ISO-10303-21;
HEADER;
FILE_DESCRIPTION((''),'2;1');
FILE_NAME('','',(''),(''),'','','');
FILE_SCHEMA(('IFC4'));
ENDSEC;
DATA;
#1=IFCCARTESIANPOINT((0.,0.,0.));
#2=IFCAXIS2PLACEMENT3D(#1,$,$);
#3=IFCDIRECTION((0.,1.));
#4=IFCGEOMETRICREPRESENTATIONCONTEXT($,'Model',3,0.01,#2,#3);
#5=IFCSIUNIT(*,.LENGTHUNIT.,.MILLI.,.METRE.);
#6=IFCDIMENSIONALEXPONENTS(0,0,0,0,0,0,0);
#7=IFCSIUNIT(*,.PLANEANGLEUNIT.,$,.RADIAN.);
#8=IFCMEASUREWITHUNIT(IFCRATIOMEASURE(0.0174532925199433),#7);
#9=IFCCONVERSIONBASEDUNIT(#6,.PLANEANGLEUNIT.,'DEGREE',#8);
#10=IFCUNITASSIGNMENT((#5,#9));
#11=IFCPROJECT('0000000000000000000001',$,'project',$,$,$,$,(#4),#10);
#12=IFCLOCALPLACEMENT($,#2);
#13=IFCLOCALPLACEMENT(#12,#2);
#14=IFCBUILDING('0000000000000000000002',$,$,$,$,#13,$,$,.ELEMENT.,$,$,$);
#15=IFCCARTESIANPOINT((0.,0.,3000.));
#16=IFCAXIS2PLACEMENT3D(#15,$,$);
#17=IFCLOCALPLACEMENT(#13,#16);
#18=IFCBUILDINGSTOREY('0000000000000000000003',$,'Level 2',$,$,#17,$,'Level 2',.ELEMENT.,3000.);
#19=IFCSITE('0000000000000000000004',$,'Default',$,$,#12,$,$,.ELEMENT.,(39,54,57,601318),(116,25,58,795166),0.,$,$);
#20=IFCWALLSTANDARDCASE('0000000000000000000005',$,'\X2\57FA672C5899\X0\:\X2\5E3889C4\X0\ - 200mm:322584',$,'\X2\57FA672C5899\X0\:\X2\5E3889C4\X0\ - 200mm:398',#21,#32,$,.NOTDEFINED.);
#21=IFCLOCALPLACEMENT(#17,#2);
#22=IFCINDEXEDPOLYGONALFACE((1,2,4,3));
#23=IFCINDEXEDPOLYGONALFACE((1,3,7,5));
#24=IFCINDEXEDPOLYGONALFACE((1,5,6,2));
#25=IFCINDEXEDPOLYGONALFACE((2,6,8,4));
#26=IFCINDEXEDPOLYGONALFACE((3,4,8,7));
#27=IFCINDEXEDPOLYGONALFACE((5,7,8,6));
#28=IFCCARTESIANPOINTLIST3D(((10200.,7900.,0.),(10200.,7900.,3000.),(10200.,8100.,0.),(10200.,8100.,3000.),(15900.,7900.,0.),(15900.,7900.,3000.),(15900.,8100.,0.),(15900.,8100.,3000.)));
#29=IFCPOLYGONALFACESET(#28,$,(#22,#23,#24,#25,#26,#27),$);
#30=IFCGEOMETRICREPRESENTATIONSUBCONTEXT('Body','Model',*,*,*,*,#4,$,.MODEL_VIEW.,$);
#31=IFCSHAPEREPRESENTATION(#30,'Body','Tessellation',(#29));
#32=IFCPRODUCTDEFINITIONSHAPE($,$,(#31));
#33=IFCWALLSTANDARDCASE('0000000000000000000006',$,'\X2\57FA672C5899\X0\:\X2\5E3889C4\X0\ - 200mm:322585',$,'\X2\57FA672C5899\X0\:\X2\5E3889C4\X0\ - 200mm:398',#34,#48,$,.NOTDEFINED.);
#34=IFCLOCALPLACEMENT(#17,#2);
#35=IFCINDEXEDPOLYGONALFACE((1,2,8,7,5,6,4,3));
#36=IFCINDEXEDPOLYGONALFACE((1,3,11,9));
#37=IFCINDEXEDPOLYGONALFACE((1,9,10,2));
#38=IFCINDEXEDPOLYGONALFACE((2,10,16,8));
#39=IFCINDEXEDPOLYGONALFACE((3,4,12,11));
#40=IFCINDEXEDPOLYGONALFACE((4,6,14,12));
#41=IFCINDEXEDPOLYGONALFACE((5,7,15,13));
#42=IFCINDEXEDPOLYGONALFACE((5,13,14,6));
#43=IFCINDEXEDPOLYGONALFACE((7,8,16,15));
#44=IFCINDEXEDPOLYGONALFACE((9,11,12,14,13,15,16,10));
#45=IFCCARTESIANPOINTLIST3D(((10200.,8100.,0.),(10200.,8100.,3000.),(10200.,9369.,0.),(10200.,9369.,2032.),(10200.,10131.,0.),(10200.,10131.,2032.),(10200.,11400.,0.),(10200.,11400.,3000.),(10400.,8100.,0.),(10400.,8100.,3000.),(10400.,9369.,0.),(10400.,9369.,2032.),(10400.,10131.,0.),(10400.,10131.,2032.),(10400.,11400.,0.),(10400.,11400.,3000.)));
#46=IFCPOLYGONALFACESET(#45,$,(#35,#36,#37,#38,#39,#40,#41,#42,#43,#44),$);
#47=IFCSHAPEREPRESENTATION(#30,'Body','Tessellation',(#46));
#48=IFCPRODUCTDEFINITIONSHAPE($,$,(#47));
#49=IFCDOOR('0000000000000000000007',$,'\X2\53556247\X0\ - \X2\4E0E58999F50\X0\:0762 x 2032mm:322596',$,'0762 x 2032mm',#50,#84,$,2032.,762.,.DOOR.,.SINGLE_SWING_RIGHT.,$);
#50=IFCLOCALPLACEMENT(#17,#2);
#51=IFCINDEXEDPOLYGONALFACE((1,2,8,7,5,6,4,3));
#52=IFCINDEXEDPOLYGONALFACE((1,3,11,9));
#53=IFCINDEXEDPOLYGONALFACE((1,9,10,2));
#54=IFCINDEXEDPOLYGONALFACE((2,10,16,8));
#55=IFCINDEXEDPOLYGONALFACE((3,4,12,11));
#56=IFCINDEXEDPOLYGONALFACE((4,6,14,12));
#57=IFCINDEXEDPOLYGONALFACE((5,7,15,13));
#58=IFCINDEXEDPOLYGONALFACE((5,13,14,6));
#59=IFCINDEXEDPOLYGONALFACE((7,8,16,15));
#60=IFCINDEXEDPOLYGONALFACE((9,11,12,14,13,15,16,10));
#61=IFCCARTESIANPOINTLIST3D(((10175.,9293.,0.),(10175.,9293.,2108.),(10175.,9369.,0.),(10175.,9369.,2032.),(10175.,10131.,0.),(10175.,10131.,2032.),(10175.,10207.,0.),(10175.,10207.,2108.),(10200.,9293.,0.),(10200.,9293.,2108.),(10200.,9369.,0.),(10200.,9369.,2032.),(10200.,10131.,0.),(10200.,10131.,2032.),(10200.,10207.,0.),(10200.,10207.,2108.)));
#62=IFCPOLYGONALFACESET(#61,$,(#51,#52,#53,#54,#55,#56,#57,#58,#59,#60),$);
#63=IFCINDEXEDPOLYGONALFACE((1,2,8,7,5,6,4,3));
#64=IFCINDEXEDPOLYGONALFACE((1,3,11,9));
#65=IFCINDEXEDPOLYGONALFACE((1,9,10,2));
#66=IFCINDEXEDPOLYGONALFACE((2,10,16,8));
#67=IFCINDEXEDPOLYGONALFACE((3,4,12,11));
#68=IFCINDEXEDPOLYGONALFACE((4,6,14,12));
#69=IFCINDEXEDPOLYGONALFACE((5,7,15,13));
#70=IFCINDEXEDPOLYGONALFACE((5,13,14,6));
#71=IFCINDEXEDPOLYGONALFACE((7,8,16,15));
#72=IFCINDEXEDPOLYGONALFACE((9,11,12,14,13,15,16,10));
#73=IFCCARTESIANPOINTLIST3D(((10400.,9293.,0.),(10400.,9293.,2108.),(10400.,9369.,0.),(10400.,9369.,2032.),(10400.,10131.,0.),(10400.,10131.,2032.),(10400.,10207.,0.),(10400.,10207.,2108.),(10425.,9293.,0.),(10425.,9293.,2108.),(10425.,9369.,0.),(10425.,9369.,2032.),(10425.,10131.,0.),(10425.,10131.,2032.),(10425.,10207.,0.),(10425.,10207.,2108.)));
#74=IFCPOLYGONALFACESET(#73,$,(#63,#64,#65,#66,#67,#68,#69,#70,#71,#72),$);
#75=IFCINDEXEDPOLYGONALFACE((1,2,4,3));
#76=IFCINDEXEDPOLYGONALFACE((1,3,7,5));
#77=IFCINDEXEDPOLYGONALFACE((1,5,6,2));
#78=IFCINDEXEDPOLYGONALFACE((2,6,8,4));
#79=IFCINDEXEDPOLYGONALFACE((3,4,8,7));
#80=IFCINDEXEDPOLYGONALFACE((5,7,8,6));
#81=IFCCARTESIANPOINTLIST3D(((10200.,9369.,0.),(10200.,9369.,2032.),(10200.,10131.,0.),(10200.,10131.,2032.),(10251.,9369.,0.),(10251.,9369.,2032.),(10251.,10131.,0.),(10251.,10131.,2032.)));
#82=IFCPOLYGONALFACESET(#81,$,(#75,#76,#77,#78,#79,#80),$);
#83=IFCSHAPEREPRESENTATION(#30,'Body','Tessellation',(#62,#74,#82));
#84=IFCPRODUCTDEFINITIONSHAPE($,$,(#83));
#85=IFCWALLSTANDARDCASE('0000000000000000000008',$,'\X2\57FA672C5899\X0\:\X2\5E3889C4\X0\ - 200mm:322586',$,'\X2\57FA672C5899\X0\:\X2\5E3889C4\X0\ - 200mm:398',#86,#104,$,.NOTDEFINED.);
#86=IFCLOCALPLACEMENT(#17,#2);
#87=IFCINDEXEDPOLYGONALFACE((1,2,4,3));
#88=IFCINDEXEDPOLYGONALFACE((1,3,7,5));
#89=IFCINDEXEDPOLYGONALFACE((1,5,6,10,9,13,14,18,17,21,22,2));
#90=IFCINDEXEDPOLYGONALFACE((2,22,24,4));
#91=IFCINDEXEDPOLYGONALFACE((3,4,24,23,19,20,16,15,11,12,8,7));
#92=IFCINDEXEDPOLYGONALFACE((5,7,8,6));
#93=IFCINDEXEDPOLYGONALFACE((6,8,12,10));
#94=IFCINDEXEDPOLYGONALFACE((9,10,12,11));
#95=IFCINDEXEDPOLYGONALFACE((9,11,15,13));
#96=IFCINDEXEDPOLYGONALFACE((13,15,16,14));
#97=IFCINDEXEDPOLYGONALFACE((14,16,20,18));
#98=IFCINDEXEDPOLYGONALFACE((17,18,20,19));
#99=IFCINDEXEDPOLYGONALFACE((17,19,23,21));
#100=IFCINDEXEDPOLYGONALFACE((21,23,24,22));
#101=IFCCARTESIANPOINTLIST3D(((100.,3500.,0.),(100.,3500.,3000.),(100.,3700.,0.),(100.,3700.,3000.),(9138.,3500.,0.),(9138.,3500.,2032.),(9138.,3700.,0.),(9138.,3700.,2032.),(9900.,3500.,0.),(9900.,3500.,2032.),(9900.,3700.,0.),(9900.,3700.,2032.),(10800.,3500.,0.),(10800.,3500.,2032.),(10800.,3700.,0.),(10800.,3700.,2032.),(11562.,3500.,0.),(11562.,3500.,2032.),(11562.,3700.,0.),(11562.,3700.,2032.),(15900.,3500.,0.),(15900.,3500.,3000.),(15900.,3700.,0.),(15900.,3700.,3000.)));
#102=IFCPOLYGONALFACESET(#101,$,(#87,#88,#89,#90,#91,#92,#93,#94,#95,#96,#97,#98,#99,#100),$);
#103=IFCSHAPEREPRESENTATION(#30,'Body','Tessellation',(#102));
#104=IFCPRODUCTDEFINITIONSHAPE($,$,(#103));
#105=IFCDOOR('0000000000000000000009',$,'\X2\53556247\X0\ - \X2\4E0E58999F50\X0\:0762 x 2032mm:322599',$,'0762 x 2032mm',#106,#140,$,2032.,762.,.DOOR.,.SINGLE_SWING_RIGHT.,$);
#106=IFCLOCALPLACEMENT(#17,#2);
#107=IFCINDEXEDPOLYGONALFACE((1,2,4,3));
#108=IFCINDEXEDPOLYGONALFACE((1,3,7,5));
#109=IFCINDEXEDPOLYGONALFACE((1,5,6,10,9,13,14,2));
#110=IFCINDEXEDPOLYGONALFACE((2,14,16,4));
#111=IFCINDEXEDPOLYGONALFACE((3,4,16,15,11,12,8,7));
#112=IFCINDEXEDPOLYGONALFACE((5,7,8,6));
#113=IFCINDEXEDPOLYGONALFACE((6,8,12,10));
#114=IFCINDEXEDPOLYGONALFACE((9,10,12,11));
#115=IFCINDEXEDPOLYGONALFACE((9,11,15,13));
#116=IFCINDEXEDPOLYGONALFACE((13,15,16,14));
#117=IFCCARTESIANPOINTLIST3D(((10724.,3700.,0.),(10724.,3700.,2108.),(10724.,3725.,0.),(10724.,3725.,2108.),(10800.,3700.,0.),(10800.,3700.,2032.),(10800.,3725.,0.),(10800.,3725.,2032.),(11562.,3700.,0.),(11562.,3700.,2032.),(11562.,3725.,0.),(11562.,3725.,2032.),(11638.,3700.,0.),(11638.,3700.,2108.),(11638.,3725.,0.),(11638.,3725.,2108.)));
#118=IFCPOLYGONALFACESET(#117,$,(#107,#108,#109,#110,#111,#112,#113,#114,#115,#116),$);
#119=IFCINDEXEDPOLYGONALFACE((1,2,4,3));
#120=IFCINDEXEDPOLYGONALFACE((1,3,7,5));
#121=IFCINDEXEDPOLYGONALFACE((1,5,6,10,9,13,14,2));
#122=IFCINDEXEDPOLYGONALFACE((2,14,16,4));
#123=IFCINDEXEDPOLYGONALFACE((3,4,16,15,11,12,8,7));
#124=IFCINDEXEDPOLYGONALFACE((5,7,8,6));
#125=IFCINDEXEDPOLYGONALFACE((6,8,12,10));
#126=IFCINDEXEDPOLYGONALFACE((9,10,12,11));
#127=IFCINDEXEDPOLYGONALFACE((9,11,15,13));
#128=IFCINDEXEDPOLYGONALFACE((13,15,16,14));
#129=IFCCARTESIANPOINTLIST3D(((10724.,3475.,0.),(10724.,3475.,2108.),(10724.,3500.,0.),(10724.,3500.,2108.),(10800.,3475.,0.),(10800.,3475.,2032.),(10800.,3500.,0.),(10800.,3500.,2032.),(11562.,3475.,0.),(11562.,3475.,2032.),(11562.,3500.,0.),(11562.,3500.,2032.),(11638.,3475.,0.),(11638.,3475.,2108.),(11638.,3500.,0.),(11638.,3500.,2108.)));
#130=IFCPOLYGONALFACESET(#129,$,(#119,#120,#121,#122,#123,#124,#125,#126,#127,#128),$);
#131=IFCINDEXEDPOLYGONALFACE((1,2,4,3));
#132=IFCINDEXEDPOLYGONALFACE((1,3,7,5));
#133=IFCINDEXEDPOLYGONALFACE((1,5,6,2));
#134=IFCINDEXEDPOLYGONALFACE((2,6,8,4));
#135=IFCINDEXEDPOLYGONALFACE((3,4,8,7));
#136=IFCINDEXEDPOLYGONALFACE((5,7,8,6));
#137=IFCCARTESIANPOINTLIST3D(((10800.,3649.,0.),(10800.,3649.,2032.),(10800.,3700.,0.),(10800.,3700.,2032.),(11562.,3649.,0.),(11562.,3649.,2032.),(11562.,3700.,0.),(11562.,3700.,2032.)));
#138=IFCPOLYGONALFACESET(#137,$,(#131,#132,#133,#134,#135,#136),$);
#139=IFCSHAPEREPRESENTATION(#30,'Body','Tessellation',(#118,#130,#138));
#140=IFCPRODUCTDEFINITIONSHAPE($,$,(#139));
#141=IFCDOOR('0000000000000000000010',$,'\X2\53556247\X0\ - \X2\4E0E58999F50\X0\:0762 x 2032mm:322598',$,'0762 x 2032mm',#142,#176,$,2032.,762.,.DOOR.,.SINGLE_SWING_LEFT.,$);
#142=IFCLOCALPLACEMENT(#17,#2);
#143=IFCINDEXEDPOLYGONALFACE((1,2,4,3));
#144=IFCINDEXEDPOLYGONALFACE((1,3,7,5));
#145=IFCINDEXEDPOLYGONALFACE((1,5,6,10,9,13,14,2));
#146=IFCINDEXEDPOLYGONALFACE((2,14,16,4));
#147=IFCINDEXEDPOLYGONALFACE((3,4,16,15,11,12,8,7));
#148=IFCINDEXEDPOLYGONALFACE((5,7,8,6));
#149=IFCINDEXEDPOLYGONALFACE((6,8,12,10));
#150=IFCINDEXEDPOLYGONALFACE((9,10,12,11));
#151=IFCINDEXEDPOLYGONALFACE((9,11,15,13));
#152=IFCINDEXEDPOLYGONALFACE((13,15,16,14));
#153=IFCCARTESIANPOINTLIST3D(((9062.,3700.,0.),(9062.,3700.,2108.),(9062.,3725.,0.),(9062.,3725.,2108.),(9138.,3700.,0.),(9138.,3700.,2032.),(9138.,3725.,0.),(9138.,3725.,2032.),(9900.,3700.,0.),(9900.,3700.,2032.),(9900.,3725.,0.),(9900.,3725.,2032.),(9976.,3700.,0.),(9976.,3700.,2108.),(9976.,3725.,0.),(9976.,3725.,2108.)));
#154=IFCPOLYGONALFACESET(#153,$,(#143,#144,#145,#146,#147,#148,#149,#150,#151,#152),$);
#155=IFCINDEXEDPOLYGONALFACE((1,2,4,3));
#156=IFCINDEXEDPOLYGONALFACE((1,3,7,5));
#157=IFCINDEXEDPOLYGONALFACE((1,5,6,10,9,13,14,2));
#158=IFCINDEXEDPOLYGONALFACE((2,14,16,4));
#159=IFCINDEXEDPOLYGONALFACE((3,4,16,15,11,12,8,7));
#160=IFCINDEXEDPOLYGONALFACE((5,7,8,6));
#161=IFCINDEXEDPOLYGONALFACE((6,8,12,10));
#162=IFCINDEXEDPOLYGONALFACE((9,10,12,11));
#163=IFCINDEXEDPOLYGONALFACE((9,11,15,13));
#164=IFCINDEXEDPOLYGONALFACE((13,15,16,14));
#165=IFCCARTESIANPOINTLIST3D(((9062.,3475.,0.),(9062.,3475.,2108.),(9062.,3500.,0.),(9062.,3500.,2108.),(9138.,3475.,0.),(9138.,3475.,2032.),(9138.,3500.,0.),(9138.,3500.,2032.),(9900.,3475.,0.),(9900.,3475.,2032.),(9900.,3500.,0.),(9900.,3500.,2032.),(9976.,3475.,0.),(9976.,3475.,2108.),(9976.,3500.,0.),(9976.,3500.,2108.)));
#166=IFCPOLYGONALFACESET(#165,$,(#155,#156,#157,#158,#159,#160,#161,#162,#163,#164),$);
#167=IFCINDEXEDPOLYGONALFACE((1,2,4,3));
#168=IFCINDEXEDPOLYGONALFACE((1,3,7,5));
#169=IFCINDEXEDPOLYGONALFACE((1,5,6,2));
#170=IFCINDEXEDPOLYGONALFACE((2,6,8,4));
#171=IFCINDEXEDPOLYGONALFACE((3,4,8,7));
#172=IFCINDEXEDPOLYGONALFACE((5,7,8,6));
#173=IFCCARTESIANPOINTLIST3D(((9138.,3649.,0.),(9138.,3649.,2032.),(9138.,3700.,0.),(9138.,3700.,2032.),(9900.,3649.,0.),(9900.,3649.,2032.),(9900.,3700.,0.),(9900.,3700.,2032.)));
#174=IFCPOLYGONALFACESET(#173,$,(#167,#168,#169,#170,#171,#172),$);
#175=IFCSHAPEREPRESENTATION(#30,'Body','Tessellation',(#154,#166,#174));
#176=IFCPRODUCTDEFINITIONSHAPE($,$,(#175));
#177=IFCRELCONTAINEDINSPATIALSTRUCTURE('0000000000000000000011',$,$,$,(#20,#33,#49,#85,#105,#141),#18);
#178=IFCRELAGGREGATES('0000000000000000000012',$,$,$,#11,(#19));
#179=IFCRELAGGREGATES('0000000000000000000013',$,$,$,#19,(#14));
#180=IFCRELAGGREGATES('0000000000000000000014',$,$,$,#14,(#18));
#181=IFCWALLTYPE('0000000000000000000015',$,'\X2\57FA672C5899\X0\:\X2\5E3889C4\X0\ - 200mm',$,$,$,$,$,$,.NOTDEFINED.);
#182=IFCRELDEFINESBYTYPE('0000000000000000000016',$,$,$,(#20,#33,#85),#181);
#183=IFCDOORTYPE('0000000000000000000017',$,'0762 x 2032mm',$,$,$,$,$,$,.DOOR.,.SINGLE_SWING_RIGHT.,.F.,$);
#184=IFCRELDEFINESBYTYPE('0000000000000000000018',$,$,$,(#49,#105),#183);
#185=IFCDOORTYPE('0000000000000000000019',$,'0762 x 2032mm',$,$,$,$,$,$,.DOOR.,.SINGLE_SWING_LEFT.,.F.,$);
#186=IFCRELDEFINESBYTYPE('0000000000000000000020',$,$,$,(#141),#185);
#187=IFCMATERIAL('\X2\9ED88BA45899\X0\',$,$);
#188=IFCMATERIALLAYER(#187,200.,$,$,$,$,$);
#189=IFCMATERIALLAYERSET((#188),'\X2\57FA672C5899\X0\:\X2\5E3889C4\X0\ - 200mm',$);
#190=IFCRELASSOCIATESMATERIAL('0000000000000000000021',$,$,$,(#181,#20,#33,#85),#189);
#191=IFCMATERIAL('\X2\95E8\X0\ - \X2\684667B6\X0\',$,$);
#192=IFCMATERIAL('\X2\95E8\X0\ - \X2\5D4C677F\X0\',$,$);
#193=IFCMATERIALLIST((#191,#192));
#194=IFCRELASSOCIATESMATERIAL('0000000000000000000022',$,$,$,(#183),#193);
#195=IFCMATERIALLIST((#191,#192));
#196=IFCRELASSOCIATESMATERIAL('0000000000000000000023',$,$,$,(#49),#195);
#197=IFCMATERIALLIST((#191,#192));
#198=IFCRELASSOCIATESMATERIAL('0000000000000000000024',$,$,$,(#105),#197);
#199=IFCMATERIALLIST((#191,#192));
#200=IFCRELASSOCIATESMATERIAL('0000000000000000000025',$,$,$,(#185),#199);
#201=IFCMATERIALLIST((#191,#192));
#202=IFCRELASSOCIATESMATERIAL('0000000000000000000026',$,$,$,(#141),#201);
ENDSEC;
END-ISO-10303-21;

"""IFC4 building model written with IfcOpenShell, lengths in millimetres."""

from ifc_helpers import new_model, entity, si_unit, converted_unit, direction, frame, frame_2d, origin, place, context, subcontext, project, spatial, polyline, rectangle, outline, extrude, source, transform, mapped, material, material_list, layer, layer_set, layer_usage, type_object, type_shapes, element, fill, save


model = new_model("IFC4")

# Units and contexts
model_context = context("Model", 3, precision=0.01, world=origin(), true_north=direction((0.0, 1.0)))
body_context = subcontext(model_context, "Body", "Model", "MODEL_VIEW")
ifc_project = project(units=[si_unit("LENGTHUNIT", "METRE", prefix="MILLI"), converted_unit("PLANEANGLEUNIT", "DEGREE", entity("IfcRatioMeasure", 0.0174532925199433), si_unit("PLANEANGLEUNIT", "RADIAN"), dimensions=[0, 0, 0, 0, 0, 0, 0])], contexts=[model_context])

# Site, building, storey
site_placement = place(None, origin())
site = spatial("IfcSite", under=ifc_project, at=site_placement, Name="Default", CompositionType="ELEMENT", RefLatitude=(39, 54, 57, 601318), RefLongitude=(116, 25, 58, 795166), RefElevation=0.0)
building_placement = place(site_placement, origin())
building = spatial("IfcBuilding", under=site, at=building_placement, CompositionType="ELEMENT")
storey_placement = place(building_placement, frame((0.0, 0.0, 3000.0)))
storey = spatial("IfcBuildingStorey", under=building, at=storey_placement, Name="Level 2", LongName="Level 2", CompositionType="ELEMENT", Elevation=3000.0)

# Wall
ifc_material_1 = material(Name="默认墙")
ifc_layer_1 = layer(ifc_material_1, 200.0)
ifc_layer_set_1 = layer_set([ifc_layer_1], Name="基本墙:常规 - 200mm")
ifc_layer_usage_1 = layer_usage(ifc_layer_set_1, "AXIS2", "NEGATIVE", 100.0)
wall_type = type_object("IfcWallType", Name="基本墙:常规 - 200mm", PredefinedType="NOTDEFINED", material=ifc_layer_set_1)
wall_1_placement = place(storey_placement, frame((10200.0, 8000.0, 0.0)))
element("IfcWallStandardCase", 1, at=wall_1_placement, inside=storey, type_object=wall_type, material=ifc_layer_usage_1, Name="基本墙:常规 - 200mm:322584", ObjectType="基本墙:常规 - 200mm:398", PredefinedType="NOTDEFINED", context=body_context, shape_type="SweptSolid", body=[
    extrude(rectangle(XDim=5700.0, YDim=200.0, at=frame_2d((2850.0, 0.0), x_axis=(-1.0, 0.0))), origin(), (0.0, 0.0, 1.0), 3000.0),
])

# Wall, opening, door
ifc_layer_usage_2 = layer_usage(ifc_layer_set_1, "AXIS2", "NEGATIVE", 100.0)
wall_2_placement = place(storey_placement, frame((10300.0, 11400.0, 0.0), z_axis=(0.0, 0.0, 1.0), x_axis=(0.0, -1.0, 0.0)))
wall_2 = element("IfcWallStandardCase", 2, at=wall_2_placement, inside=storey, type_object=wall_type, material=ifc_layer_usage_2, Name="基本墙:常规 - 200mm:322585", ObjectType="基本墙:常规 - 200mm:398", PredefinedType="NOTDEFINED", context=body_context, shape_type="SweptSolid", body=[
    extrude(rectangle(XDim=3300.0, YDim=200.0, at=frame_2d((1650.0, 0.0), x_axis=(-1.0, 0.0))), origin(), (0.0, 0.0, 1.0), 3000.0),
])
opening_1_placement = place(wall_2_placement, frame((2031.0, 100.0, 0.0)))
opening_1 = element("IfcOpeningElement", 3, at=opening_1_placement, cuts=wall_2, ObjectType="Opening", PredefinedType="OPENING", context=body_context, shape_type="SweptSolid", body=[
    extrude(rectangle(XDim=762.0, YDim=2032.0, at=frame_2d((1016.0, 381.0), x_axis=(0.0, 1.0))), frame((0.0, 0.0, 0.0), z_axis=(0.0, -1.0, 0.0), x_axis=(0.0, 0.0, 1.0)), (0.0, 0.0, 1.0), 200.0),
])
ifc_material_2 = material(Name="门 - 框架")
ifc_material_3 = material(Name="门 - 嵌板")
ifc_material_list_1 = material_list([ifc_material_2, ifc_material_3])
ifc_material_list_2 = material_list([ifc_material_2, ifc_material_3])
door_type_1 = type_object("IfcDoorType", Name="0762 x 2032mm", OperationType="SINGLE_SWING_RIGHT", ParameterTakesPrecedence=False, PredefinedType="DOOR", material=ifc_material_list_2)
shared_shape_1 = source(origin(), body_context, "Body", "SweptSolid", [
    extrude(outline(polyline([(-457.0, -1073.0), (457.0, -1073.0), (457.0, 1035.0), (381.0, 1035.0), (381.0, -997.0), (-381.0, -997.0), (-381.0, 1035.0), (-457.0, 1035.0), (-457.0, -1073.0)])), frame((381.0, 200.0, 1035.0), z_axis=(0.0, 1.0, 0.0), x_axis=(1.0, 0.0, 0.0)), (0.0, 0.0, 1.0), 25.0),
    extrude(outline(polyline([(-1073.0, -457.0), (1035.0, -457.0), (1035.0, -381.0), (-997.0, -381.0), (-997.0, 381.0), (1035.0, 381.0), (1035.0, 457.0), (-1073.0, 457.0), (-1073.0, -457.0)])), frame((381.0, -25.0, 1035.0), z_axis=(0.0, 1.0, 0.0), x_axis=(0.0, 0.0, -1.0)), (0.0, 0.0, 1.0), 25.0),
    extrude(rectangle(XDim=51.0, YDim=762.0, at=frame_2d((0.0, 0.0), x_axis=(1.0, 0.0))), frame((381.0, 174.5, 0.0), z_axis=(0.0, 0.0, 1.0), x_axis=(0.0, 1.0, 0.0)), (0.0, 0.0, 1.0), 2032.0),
])
type_shapes(door_type_1, [shared_shape_1])
door_1_placement = place(opening_1_placement, frame((0.0, 0.0, 0.0), z_axis=(0.0, 0.0, 1.0), x_axis=(-1.0, 0.0, 0.0)))
door_1 = element("IfcDoor", 4, at=door_1_placement, inside=storey, type_object=door_type_1, material=ifc_material_list_1, Name="单扇 - 与墙齐:0762 x 2032mm:322596", ObjectType="0762 x 2032mm", OperationType="SINGLE_SWING_RIGHT", OverallHeight=2032.0, OverallWidth=762.0, PredefinedType="DOOR", context=body_context, shape_type="MappedRepresentation", body=[
    mapped(shared_shape_1, transform((0.0, 0.0, 0.0), scale=1.0)),
])
fill(opening_1, door_1)

# Wall, openings, doors
ifc_layer_usage_3 = layer_usage(ifc_layer_set_1, "AXIS2", "NEGATIVE", 100.0)
wall_3_placement = place(storey_placement, frame((15900.0, 3600.0, 0.0), z_axis=(0.0, 0.0, 1.0), x_axis=(-1.0, 0.0, 0.0)))
wall_3 = element("IfcWallStandardCase", 5, at=wall_3_placement, inside=storey, type_object=wall_type, material=ifc_layer_usage_3, Name="基本墙:常规 - 200mm:322586", ObjectType="基本墙:常规 - 200mm:398", PredefinedType="NOTDEFINED", context=body_context, shape_type="SweptSolid", body=[
    extrude(rectangle(XDim=15800.0, YDim=200.0, at=frame_2d((7900.0, 0.0), x_axis=(-1.0, 0.0))), origin(), (0.0, 0.0, 1.0), 3000.0),
])
opening_2_placement = place(wall_3_placement, frame((6762.0, 100.0, 0.0)))
opening_2 = element("IfcOpeningElement", 6, at=opening_2_placement, cuts=wall_3, ObjectType="Opening", PredefinedType="OPENING", context=body_context, shape_type="SweptSolid", body=[
    extrude(rectangle(XDim=762.0, YDim=2032.0, at=frame_2d((1016.0, 381.0), x_axis=(0.0, -1.0))), frame((0.0, 0.0, 0.0), z_axis=(0.0, -1.0, 0.0), x_axis=(0.0, 0.0, 1.0)), (0.0, 0.0, 1.0), 200.0),
])
opening_3_placement = place(wall_3_placement, frame((5100.0, 100.0, 0.0)))
opening_3 = element("IfcOpeningElement", 7, at=opening_3_placement, cuts=wall_3, ObjectType="Opening", PredefinedType="OPENING", context=body_context, shape_type="SweptSolid", body=[
    extrude(rectangle(XDim=762.0, YDim=2032.0, at=frame_2d((1016.0, 381.0), x_axis=(0.0, 1.0))), frame((0.0, 0.0, 0.0), z_axis=(0.0, -1.0, 0.0), x_axis=(0.0, 0.0, 1.0)), (0.0, 0.0, 1.0), 200.0),
])
ifc_material_list_3 = material_list([ifc_material_2, ifc_material_3])
door_2_placement = place(opening_3_placement, frame((0.0, 0.0, 0.0), z_axis=(0.0, 0.0, 1.0), x_axis=(-1.0, 0.0, 0.0)))
door_2 = element("IfcDoor", 8, at=door_2_placement, inside=storey, type_object=door_type_1, material=ifc_material_list_3, Name="单扇 - 与墙齐:0762 x 2032mm:322599", ObjectType="0762 x 2032mm", OperationType="SINGLE_SWING_RIGHT", OverallHeight=2032.0, OverallWidth=762.0, PredefinedType="DOOR", context=body_context, shape_type="MappedRepresentation", body=[
    mapped(shared_shape_1, transform((0.0, 0.0, 0.0), scale=1.0)),
])
fill(opening_3, door_2)
ifc_material_list_4 = material_list([ifc_material_2, ifc_material_3])
ifc_material_list_5 = material_list([ifc_material_2, ifc_material_3])
door_type_2 = type_object("IfcDoorType", Name="0762 x 2032mm", OperationType="SINGLE_SWING_LEFT", ParameterTakesPrecedence=False, PredefinedType="DOOR", material=ifc_material_list_5)
shared_shape_2 = source(origin(), body_context, "Body", "SweptSolid", [
    extrude(outline(polyline([(-457.0, -1073.0), (457.0, -1073.0), (457.0, 1035.0), (381.0, 1035.0), (381.0, -997.0), (-381.0, -997.0), (-381.0, 1035.0), (-457.0, 1035.0), (-457.0, -1073.0)])), frame((381.0, 225.0, 1035.0), z_axis=(0.0, -1.0, 0.0), x_axis=(-1.0, 0.0, 0.0)), (0.0, 0.0, 1.0), 25.0),
    extrude(outline(polyline([(-1073.0, -457.0), (1035.0, -457.0), (1035.0, -381.0), (-997.0, -381.0), (-997.0, 381.0), (1035.0, 381.0), (1035.0, 457.0), (-1073.0, 457.0), (-1073.0, -457.0)])), frame((381.0, 0.0, 1035.0), z_axis=(0.0, -1.0, 0.0), x_axis=(0.0, 0.0, -1.0)), (0.0, 0.0, 1.0), 25.0),
    extrude(rectangle(XDim=762.0, YDim=51.0, at=frame_2d((0.0, 0.0), x_axis=(1.0, 0.0))), frame((381.0, 174.5, 0.0)), (0.0, 0.0, 1.0), 2032.0),
])
type_shapes(door_type_2, [shared_shape_2])
door_3_placement = place(opening_2_placement, frame((0.0, 0.0, 0.0), z_axis=(0.0, 0.0, 1.0), x_axis=(-1.0, 0.0, 0.0)))
door_3 = element("IfcDoor", 9, at=door_3_placement, inside=storey, type_object=door_type_2, material=ifc_material_list_4, Name="单扇 - 与墙齐:0762 x 2032mm:322598", ObjectType="0762 x 2032mm", OperationType="SINGLE_SWING_LEFT", OverallHeight=2032.0, OverallWidth=762.0, PredefinedType="DOOR", context=body_context, shape_type="MappedRepresentation", body=[
    mapped(shared_shape_2, transform((0.0, 0.0, 0.0), scale=1.0)),
])
fill(opening_2, door_3)

save(model, "model.ifc")
